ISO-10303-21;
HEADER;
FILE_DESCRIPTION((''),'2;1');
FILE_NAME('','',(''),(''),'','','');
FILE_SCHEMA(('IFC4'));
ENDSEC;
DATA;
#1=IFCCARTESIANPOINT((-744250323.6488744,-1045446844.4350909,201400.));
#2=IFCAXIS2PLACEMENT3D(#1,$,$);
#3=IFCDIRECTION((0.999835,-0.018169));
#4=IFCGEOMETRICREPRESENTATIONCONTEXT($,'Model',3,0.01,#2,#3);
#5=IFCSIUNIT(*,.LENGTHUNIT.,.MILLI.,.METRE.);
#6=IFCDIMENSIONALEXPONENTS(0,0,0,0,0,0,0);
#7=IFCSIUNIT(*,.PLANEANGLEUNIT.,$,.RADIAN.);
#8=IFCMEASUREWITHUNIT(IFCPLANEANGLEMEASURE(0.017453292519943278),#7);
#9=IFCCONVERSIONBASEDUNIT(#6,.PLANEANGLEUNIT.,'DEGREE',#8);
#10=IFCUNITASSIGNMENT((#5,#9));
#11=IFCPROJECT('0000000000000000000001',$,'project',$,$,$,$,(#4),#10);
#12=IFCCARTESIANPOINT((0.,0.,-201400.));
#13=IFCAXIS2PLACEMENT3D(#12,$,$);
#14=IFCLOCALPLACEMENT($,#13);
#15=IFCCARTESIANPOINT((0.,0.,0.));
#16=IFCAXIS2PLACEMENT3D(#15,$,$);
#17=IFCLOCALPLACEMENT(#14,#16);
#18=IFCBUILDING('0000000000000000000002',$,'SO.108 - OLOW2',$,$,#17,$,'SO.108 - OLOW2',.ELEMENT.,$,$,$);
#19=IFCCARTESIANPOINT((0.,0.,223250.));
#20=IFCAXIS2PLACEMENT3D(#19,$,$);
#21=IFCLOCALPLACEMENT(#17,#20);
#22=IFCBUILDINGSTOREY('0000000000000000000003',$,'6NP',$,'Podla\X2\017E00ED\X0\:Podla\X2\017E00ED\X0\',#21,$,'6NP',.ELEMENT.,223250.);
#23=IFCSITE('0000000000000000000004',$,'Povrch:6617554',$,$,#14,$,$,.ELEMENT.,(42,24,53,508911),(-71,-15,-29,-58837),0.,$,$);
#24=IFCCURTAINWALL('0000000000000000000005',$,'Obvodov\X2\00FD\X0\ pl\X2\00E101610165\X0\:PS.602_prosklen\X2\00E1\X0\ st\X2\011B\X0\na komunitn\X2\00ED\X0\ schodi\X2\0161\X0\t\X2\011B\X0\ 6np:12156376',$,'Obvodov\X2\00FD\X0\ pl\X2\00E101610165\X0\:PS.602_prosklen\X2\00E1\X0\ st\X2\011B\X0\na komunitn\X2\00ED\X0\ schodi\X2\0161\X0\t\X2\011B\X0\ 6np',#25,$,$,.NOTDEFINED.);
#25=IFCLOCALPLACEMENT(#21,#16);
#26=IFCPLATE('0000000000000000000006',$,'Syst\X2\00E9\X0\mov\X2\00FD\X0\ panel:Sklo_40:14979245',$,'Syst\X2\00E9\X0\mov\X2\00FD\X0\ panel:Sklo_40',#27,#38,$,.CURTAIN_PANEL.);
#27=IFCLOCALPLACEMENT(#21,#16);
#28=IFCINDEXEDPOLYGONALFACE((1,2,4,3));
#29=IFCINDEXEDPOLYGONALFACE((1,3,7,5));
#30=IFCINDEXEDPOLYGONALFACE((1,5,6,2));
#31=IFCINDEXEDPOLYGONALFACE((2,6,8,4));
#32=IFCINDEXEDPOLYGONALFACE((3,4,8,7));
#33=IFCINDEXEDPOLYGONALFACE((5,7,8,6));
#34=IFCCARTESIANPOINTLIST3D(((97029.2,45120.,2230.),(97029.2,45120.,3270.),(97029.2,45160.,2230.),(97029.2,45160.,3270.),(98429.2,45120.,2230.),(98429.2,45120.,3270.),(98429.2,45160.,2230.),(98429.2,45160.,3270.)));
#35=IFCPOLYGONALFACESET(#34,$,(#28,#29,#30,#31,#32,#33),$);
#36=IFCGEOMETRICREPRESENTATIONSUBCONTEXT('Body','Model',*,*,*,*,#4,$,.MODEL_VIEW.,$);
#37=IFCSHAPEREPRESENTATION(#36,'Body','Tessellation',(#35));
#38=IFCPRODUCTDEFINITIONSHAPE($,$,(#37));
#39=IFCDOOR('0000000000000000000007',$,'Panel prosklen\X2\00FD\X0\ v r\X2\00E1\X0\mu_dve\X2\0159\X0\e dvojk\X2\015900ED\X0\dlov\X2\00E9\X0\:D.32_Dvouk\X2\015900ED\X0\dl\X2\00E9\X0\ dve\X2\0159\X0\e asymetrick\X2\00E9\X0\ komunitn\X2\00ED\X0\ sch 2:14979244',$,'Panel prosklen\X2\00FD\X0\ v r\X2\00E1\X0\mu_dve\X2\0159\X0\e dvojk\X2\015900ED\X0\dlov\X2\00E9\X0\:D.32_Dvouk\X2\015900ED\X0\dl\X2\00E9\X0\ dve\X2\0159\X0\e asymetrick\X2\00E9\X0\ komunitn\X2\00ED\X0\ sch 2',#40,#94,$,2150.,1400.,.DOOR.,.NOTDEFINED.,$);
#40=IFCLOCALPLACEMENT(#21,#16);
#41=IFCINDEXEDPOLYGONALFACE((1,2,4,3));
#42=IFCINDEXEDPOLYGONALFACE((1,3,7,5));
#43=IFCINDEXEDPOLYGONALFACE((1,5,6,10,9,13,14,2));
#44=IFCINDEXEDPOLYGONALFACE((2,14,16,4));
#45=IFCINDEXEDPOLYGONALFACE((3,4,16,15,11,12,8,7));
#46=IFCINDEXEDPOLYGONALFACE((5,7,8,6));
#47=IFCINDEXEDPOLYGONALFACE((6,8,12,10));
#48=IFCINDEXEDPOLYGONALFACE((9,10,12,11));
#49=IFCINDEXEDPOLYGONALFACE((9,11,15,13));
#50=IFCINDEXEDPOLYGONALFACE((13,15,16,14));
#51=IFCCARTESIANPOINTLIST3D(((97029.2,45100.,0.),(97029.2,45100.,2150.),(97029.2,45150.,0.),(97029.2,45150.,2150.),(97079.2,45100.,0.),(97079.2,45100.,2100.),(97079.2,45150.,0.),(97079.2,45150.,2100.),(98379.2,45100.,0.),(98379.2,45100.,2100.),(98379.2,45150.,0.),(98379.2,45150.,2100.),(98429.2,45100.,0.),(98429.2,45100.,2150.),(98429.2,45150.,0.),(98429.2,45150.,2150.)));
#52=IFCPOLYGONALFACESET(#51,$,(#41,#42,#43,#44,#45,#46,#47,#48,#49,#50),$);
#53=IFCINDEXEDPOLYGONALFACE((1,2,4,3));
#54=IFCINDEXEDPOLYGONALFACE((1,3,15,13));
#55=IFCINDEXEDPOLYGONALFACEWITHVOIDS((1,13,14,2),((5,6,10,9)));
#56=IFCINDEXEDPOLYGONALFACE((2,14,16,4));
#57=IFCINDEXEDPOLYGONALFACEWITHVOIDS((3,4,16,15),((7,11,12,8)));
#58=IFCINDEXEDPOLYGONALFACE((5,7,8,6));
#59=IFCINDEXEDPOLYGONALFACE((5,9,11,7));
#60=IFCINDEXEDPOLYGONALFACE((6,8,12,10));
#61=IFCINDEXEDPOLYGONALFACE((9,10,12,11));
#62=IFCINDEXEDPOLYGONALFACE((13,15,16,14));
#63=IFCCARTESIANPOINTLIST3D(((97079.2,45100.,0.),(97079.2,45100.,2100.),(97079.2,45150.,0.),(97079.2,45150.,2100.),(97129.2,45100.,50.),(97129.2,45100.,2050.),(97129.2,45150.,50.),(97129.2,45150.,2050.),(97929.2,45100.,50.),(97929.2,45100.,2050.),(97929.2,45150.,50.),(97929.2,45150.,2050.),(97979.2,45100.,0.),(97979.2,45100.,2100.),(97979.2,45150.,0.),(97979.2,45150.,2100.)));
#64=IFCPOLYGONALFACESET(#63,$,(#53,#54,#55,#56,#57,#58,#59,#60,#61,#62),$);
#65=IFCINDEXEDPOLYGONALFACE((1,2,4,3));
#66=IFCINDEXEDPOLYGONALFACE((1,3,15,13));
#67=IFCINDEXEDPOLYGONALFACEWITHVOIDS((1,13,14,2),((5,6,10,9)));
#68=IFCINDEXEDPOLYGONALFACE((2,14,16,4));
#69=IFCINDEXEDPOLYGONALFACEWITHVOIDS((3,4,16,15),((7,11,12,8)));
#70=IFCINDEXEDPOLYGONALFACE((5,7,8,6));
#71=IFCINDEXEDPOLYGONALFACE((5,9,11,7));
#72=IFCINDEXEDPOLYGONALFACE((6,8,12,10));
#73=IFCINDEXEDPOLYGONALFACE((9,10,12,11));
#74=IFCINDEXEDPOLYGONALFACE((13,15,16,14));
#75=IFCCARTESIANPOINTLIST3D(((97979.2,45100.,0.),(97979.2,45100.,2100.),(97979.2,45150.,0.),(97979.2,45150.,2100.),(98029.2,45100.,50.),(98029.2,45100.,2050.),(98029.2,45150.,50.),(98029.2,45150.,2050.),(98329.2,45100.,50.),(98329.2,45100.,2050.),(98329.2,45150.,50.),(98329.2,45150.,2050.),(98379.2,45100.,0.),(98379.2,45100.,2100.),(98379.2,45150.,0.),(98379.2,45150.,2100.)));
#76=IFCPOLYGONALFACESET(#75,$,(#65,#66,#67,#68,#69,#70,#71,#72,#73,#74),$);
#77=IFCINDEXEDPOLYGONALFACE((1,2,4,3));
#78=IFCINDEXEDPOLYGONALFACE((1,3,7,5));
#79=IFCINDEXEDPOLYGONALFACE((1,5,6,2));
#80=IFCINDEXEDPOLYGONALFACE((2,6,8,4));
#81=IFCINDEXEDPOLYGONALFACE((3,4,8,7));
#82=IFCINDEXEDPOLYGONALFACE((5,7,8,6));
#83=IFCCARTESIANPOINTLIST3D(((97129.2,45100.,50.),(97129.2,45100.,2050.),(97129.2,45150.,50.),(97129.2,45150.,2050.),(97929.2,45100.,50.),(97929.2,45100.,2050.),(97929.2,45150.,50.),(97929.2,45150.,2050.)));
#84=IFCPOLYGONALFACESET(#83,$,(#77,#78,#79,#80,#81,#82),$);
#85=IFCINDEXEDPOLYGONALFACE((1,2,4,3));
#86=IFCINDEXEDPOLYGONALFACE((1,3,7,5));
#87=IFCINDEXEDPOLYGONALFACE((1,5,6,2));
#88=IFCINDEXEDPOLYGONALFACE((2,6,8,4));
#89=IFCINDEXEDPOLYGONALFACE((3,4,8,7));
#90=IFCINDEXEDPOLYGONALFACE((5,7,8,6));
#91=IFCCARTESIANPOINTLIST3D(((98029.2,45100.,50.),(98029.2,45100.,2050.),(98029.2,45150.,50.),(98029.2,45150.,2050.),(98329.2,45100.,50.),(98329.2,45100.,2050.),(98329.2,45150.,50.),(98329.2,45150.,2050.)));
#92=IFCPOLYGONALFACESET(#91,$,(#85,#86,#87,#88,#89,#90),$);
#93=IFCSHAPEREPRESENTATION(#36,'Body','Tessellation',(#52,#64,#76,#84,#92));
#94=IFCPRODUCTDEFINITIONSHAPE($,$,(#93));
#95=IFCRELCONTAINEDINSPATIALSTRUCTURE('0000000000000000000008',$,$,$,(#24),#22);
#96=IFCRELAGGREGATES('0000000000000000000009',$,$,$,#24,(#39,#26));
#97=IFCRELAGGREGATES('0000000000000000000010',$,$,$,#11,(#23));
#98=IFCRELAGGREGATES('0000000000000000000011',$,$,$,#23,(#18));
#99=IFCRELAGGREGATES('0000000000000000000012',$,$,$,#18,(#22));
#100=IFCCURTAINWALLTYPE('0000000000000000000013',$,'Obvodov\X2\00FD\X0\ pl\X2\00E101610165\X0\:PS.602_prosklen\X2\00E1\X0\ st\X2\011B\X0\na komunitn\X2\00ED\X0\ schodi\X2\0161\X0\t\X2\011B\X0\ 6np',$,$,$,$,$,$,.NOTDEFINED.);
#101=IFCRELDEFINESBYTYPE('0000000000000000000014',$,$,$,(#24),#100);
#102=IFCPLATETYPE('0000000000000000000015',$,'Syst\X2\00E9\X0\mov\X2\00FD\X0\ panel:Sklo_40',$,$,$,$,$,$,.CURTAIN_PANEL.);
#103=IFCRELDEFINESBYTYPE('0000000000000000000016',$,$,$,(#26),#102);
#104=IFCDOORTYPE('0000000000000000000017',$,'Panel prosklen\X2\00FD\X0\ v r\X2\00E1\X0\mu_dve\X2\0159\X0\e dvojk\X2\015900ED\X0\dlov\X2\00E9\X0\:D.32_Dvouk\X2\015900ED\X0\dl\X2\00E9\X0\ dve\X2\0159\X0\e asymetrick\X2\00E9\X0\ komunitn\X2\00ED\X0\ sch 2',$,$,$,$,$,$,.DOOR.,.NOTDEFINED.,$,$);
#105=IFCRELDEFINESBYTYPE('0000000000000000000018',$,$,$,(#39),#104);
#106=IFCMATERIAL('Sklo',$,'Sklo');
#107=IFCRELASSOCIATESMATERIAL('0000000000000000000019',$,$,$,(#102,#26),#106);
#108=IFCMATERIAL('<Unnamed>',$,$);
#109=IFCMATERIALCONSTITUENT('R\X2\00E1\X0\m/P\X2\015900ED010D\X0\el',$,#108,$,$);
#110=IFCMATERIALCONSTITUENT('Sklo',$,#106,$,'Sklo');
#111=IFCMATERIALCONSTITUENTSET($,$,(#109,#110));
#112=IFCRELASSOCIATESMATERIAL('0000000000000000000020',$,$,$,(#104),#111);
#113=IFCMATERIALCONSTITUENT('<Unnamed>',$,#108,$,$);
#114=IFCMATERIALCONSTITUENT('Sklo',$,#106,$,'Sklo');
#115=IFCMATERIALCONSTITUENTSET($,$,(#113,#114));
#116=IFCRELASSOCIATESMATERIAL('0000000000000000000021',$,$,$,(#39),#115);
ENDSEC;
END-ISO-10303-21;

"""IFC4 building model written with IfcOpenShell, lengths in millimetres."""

from ifc_helpers import new_model, entity, si_unit, converted_unit, direction, frame, origin, place, context, subcontext, project, spatial, indexed_curve, outline, extrude, source, transform, mapped, material, constituent, constituent_set, type_object, type_shapes, element, aggregate, save


model = new_model("IFC4")

# Units and contexts
model_context = context("Model", 3, precision=0.01, world=frame((-744250323.6488744, -1045446844.4350909, 201400.0)), true_north=direction((0.999835, -0.018169)))
body_context = subcontext(model_context, "Body", "Model", "MODEL_VIEW")
ifc_project = project(units=[si_unit("LENGTHUNIT", "METRE", prefix="MILLI"), converted_unit("PLANEANGLEUNIT", "DEGREE", entity("IfcPlaneAngleMeasure", 0.017453292519943278), si_unit("PLANEANGLEUNIT", "RADIAN"), dimensions=[0, 0, 0, 0, 0, 0, 0])], contexts=[model_context])

# Site, building, storey
site_placement = place(None, frame((0.0, 0.0, -201400.0)))
site = spatial("IfcSite", under=ifc_project, at=site_placement, Name="Povrch:6617554", CompositionType="ELEMENT", RefLatitude=(42, 24, 53, 508911), RefLongitude=(-71, -15, -29, -58837), RefElevation=0.0)
building_placement = place(site_placement, origin())
building = spatial("IfcBuilding", under=site, at=building_placement, Name="SO.108 - OLOW2", LongName="SO.108 - OLOW2", CompositionType="ELEMENT")
storey_placement = place(building_placement, frame((0.0, 0.0, 223250.0)))
storey = spatial("IfcBuildingStorey", under=building, at=storey_placement, Name="6NP", ObjectType="Podlaží:Podlaží", LongName="6NP", CompositionType="ELEMENT", Elevation=223250.0)

# Curtain wall
curtain_wall_type_1 = type_object("IfcCurtainWallType", Name="Obvodový plášť:PS.602_prosklená stěna komunitní schodiště 6np", PredefinedType="NOTDEFINED")
curtain_wall_1_placement = place(storey_placement, frame((0.0, 0.0, -223250.0)))
curtain_wall_1 = element("IfcCurtainWall", 1, at=curtain_wall_1_placement, inside=storey, type_object=curtain_wall_type_1, Name="Obvodový plášť:PS.602_prosklená stěna komunitní schodiště 6np:12156376", ObjectType="Obvodový plášť:PS.602_prosklená stěna komunitní schodiště 6np", PredefinedType="NOTDEFINED")
ifc_material_1 = material(Name="<Unnamed>")

# Plate
ifc_material_2 = material(Name="Sklo", Category="Sklo")
plate_type_1 = type_object("IfcPlateType", Name="Systémový panel:Sklo_40", PredefinedType="CURTAIN_PANEL", material=ifc_material_2)
shared_shape_1 = source(origin(), body_context, "Body", "SweptSolid", [
    extrude(outline(indexed_curve([(-20.0, -700.0), (20.0, -700.0), (20.0, 700.0), (-20.0, 700.0), (-20.0, -700.0)], self_intersect=False)), frame((0.0, 0.0, 0.0), z_axis=(0.0, 0.0, 1.0), x_axis=(0.0, 1.0, 0.0)), (0.0, 0.0, 1.0), 1040.0),
])
type_shapes(plate_type_1, [shared_shape_1])
plate_1_placement = place(curtain_wall_1_placement, frame((97729.2, 45140.0, 225480.0), z_axis=(0.0, 0.0, 1.0), x_axis=(-1.0, 0.0, 0.0)))
plate_1 = element("IfcPlate", 2, at=plate_1_placement, type_object=plate_type_1, material=ifc_material_2, Name="Systémový panel:Sklo_40:14979245", ObjectType="Systémový panel:Sklo_40", PredefinedType="CURTAIN_PANEL", context=body_context, shape_type="MappedRepresentation", body=[
    mapped(shared_shape_1, transform((0.0, 0.0, 0.0), scale=1.0)),
])

# Door
ifc_constituent_1 = constituent(ifc_material_1, Name="<Unnamed>")
ifc_constituent_2 = constituent(ifc_material_2, Name="Sklo", Category="Sklo")
ifc_constituent_set_1 = constituent_set(constituents=[ifc_constituent_1, ifc_constituent_2])
ifc_constituent_3 = constituent(ifc_material_1, Name="Rám/Příčel")
ifc_constituent_4 = constituent(ifc_material_2, Name="Sklo", Category="Sklo")
ifc_constituent_set_2 = constituent_set(constituents=[ifc_constituent_3, ifc_constituent_4])
door_type = type_object("IfcDoorType", Name="Panel prosklený v rámu_dveře dvojkřídlové:D.32_Dvoukřídlé dveře asymetrické komunitní sch 2", OperationType="NOTDEFINED", PredefinedType="DOOR", material=ifc_constituent_set_2)
shared_shape_2 = source(origin(), body_context, "Body", "SweptSolid", [
    extrude(outline(indexed_curve([(-700.0, -1087.5), (700.0, -1087.5), (700.0, 1062.5), (650.0, 1062.5), (650.0, -1037.5), (-650.0, -1037.5), (-650.0, 1062.5), (-700.0, 1062.5), (-700.0, -1087.5)], self_intersect=False)), frame((0.0, -10.0, 1062.5), z_axis=(0.0, 1.0, 0.0), x_axis=(1.0, 0.0, 0.0)), (0.0, 0.0, 1.0), 50.0),
    extrude(outline(indexed_curve([(-1050.0, -450.0), (1050.0, -450.0), (1050.0, 450.0), (-1050.0, 450.0), (-1050.0, -450.0)], self_intersect=False), holes=[indexed_curve([(-1000.0, -400.0), (-1000.0, 400.0), (1000.0, 400.0), (1000.0, -400.0), (-1000.0, -400.0)], self_intersect=False)]), frame((200.0, -10.0, 1050.0), z_axis=(0.0, 1.0, 0.0), x_axis=(0.0, 0.0, -1.0)), (0.0, 0.0, 1.0), 50.0),
    extrude(outline(indexed_curve([(-1050.0, -200.0), (1050.0, -200.0), (1050.0, 200.0), (-1050.0, 200.0), (-1050.0, -200.0)], self_intersect=False), holes=[indexed_curve([(-1000.0, -150.0), (-1000.0, 150.0), (1000.0, 150.0), (1000.0, -150.0), (-1000.0, -150.0)], self_intersect=False)]), frame((-450.0, -10.0, 1050.0), z_axis=(0.0, 1.0, 0.0), x_axis=(0.0, 0.0, -1.0)), (0.0, 0.0, 1.0), 50.0),
    extrude(outline(indexed_curve([(-25.0, -400.0), (25.0, -400.0), (25.0, 400.0), (-25.0, 400.0), (-25.0, -400.0)], self_intersect=False)), frame((200.0, 15.0, 50.0), z_axis=(0.0, 0.0, 1.0), x_axis=(0.0, 1.0, 0.0)), (0.0, 0.0, 1.0), 2000.0),
    extrude(outline(indexed_curve([(-25.0, -150.0), (25.0, -150.0), (25.0, 150.0), (-25.0, 150.0), (-25.0, -150.0)], self_intersect=False)), frame((-450.0, 15.0, 50.0), z_axis=(0.0, 0.0, 1.0), x_axis=(0.0, 1.0, 0.0)), (0.0, 0.0, 1.0), 2000.0),
])
type_shapes(door_type, [shared_shape_2])
door_placement = place(curtain_wall_1_placement, frame((97729.2, 45140.0, 223250.0), z_axis=(0.0, 0.0, 1.0), x_axis=(-1.0, 0.0, 0.0)))
door = element("IfcDoor", 3, at=door_placement, type_object=door_type, material=ifc_constituent_set_1, Name="Panel prosklený v rámu_dveře dvojkřídlové:D.32_Dvoukřídlé dveře asymetrické komunitní sch 2:14979244", ObjectType="Panel prosklený v rámu_dveře dvojkřídlové:D.32_Dvoukřídlé dveře asymetrické komunitní sch 2", OperationType="NOTDEFINED", OverallHeight=2150.0, OverallWidth=1400.0, PredefinedType="DOOR", context=body_context, shape_type="MappedRepresentation", body=[
    mapped(shared_shape_2, transform((0.0, 0.0, 0.0), scale=1.0)),
])
aggregate(curtain_wall_1, [door, plate_1])

save(model, "model.ifc")
